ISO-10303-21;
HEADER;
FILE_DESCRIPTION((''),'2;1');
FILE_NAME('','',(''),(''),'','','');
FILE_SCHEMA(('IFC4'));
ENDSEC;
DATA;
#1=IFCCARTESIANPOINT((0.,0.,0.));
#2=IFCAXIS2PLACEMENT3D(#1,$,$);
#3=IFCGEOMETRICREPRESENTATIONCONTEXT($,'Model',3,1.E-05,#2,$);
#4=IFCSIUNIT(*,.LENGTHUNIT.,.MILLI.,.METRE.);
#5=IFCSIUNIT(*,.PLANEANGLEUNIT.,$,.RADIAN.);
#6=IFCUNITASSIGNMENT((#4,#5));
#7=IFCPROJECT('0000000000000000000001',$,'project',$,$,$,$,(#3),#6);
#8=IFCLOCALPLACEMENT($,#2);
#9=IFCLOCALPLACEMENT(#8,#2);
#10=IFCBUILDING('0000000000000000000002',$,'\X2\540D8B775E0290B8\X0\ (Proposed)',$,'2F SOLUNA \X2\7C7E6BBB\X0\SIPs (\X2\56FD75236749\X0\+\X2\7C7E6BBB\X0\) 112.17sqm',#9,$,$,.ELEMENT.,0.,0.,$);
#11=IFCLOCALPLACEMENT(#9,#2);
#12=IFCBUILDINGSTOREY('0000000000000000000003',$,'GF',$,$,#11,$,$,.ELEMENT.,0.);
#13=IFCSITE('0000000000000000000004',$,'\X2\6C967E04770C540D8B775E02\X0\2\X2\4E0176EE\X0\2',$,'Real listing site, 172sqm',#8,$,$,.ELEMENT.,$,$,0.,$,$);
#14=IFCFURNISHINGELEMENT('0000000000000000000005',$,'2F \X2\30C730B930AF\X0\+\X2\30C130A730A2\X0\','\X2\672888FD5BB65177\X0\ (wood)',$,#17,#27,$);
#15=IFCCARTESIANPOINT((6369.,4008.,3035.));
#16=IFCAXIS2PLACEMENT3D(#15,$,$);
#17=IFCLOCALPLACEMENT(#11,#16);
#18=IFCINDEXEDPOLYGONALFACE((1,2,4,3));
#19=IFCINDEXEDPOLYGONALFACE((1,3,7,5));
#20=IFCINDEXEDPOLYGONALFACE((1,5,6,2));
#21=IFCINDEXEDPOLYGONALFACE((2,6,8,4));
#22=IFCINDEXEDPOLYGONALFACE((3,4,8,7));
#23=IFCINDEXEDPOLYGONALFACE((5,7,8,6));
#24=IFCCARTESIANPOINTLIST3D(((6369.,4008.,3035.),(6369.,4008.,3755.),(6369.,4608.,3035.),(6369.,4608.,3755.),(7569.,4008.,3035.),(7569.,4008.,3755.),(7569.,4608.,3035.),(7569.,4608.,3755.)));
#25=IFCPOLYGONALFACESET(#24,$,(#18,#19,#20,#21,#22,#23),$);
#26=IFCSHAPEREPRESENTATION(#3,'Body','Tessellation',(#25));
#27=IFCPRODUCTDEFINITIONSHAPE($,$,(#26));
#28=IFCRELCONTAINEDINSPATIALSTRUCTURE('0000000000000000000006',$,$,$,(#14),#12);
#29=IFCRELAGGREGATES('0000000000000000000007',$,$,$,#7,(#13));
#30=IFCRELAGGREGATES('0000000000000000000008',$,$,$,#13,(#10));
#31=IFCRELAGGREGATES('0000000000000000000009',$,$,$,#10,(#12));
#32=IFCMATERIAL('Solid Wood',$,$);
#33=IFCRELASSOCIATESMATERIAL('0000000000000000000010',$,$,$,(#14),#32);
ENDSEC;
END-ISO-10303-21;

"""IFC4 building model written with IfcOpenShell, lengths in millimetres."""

from ifc_helpers import new_model, si_unit, frame, frame_2d, origin, place, context, project, spatial, rectangle, extrude, material, element, save


model = new_model("IFC4")

# Units and contexts
model_context = context("Model", 3, precision=1e-05, world=origin())
ifc_project = project(units=[si_unit("LENGTHUNIT", "METRE", prefix="MILLI"), si_unit("PLANEANGLEUNIT", "RADIAN")], contexts=[model_context])

# Site, building, storey
site_placement = place(None, origin())
site = spatial("IfcSite", under=ifc_project, at=site_placement, Name="沖縄県名護市2丁目2", ObjectType="Real listing site, 172sqm", CompositionType="ELEMENT", RefElevation=0.0)
building_placement = place(site_placement, origin())
building = spatial("IfcBuilding", under=site, at=building_placement, Name="名護市邸 (Proposed)", ObjectType="2F SOLUNA 籾殻SIPs (国産杉+籾殻) 112.17sqm", CompositionType="ELEMENT", ElevationOfRefHeight=0.0, ElevationOfTerrain=0.0)
storey_placement = place(building_placement, origin())
storey = spatial("IfcBuildingStorey", under=building, at=storey_placement, Name="GF", CompositionType="ELEMENT", Elevation=0.0)

# Shared definitions
ifc_material_1 = material(Name="Solid Wood")

# Furnishing element
furnishing_1_placement = place(storey_placement, frame((6369.0, 4008.0, 3035.0)))
element("IfcFurnishingElement", 1, at=furnishing_1_placement, inside=storey, material=ifc_material_1, Name="2F デスク+チェア", Description="木製家具 (wood)", context=model_context, shape_type="SweptSolid", body=[
    extrude(rectangle(XDim=1200.0, YDim=600.0, at=frame_2d((600.0, 300.0))), frame((6369.0, 4008.0, 3035.0)), (0.0, 0.0, 1.0), 720.0),
])

save(model, "model.ifc")
